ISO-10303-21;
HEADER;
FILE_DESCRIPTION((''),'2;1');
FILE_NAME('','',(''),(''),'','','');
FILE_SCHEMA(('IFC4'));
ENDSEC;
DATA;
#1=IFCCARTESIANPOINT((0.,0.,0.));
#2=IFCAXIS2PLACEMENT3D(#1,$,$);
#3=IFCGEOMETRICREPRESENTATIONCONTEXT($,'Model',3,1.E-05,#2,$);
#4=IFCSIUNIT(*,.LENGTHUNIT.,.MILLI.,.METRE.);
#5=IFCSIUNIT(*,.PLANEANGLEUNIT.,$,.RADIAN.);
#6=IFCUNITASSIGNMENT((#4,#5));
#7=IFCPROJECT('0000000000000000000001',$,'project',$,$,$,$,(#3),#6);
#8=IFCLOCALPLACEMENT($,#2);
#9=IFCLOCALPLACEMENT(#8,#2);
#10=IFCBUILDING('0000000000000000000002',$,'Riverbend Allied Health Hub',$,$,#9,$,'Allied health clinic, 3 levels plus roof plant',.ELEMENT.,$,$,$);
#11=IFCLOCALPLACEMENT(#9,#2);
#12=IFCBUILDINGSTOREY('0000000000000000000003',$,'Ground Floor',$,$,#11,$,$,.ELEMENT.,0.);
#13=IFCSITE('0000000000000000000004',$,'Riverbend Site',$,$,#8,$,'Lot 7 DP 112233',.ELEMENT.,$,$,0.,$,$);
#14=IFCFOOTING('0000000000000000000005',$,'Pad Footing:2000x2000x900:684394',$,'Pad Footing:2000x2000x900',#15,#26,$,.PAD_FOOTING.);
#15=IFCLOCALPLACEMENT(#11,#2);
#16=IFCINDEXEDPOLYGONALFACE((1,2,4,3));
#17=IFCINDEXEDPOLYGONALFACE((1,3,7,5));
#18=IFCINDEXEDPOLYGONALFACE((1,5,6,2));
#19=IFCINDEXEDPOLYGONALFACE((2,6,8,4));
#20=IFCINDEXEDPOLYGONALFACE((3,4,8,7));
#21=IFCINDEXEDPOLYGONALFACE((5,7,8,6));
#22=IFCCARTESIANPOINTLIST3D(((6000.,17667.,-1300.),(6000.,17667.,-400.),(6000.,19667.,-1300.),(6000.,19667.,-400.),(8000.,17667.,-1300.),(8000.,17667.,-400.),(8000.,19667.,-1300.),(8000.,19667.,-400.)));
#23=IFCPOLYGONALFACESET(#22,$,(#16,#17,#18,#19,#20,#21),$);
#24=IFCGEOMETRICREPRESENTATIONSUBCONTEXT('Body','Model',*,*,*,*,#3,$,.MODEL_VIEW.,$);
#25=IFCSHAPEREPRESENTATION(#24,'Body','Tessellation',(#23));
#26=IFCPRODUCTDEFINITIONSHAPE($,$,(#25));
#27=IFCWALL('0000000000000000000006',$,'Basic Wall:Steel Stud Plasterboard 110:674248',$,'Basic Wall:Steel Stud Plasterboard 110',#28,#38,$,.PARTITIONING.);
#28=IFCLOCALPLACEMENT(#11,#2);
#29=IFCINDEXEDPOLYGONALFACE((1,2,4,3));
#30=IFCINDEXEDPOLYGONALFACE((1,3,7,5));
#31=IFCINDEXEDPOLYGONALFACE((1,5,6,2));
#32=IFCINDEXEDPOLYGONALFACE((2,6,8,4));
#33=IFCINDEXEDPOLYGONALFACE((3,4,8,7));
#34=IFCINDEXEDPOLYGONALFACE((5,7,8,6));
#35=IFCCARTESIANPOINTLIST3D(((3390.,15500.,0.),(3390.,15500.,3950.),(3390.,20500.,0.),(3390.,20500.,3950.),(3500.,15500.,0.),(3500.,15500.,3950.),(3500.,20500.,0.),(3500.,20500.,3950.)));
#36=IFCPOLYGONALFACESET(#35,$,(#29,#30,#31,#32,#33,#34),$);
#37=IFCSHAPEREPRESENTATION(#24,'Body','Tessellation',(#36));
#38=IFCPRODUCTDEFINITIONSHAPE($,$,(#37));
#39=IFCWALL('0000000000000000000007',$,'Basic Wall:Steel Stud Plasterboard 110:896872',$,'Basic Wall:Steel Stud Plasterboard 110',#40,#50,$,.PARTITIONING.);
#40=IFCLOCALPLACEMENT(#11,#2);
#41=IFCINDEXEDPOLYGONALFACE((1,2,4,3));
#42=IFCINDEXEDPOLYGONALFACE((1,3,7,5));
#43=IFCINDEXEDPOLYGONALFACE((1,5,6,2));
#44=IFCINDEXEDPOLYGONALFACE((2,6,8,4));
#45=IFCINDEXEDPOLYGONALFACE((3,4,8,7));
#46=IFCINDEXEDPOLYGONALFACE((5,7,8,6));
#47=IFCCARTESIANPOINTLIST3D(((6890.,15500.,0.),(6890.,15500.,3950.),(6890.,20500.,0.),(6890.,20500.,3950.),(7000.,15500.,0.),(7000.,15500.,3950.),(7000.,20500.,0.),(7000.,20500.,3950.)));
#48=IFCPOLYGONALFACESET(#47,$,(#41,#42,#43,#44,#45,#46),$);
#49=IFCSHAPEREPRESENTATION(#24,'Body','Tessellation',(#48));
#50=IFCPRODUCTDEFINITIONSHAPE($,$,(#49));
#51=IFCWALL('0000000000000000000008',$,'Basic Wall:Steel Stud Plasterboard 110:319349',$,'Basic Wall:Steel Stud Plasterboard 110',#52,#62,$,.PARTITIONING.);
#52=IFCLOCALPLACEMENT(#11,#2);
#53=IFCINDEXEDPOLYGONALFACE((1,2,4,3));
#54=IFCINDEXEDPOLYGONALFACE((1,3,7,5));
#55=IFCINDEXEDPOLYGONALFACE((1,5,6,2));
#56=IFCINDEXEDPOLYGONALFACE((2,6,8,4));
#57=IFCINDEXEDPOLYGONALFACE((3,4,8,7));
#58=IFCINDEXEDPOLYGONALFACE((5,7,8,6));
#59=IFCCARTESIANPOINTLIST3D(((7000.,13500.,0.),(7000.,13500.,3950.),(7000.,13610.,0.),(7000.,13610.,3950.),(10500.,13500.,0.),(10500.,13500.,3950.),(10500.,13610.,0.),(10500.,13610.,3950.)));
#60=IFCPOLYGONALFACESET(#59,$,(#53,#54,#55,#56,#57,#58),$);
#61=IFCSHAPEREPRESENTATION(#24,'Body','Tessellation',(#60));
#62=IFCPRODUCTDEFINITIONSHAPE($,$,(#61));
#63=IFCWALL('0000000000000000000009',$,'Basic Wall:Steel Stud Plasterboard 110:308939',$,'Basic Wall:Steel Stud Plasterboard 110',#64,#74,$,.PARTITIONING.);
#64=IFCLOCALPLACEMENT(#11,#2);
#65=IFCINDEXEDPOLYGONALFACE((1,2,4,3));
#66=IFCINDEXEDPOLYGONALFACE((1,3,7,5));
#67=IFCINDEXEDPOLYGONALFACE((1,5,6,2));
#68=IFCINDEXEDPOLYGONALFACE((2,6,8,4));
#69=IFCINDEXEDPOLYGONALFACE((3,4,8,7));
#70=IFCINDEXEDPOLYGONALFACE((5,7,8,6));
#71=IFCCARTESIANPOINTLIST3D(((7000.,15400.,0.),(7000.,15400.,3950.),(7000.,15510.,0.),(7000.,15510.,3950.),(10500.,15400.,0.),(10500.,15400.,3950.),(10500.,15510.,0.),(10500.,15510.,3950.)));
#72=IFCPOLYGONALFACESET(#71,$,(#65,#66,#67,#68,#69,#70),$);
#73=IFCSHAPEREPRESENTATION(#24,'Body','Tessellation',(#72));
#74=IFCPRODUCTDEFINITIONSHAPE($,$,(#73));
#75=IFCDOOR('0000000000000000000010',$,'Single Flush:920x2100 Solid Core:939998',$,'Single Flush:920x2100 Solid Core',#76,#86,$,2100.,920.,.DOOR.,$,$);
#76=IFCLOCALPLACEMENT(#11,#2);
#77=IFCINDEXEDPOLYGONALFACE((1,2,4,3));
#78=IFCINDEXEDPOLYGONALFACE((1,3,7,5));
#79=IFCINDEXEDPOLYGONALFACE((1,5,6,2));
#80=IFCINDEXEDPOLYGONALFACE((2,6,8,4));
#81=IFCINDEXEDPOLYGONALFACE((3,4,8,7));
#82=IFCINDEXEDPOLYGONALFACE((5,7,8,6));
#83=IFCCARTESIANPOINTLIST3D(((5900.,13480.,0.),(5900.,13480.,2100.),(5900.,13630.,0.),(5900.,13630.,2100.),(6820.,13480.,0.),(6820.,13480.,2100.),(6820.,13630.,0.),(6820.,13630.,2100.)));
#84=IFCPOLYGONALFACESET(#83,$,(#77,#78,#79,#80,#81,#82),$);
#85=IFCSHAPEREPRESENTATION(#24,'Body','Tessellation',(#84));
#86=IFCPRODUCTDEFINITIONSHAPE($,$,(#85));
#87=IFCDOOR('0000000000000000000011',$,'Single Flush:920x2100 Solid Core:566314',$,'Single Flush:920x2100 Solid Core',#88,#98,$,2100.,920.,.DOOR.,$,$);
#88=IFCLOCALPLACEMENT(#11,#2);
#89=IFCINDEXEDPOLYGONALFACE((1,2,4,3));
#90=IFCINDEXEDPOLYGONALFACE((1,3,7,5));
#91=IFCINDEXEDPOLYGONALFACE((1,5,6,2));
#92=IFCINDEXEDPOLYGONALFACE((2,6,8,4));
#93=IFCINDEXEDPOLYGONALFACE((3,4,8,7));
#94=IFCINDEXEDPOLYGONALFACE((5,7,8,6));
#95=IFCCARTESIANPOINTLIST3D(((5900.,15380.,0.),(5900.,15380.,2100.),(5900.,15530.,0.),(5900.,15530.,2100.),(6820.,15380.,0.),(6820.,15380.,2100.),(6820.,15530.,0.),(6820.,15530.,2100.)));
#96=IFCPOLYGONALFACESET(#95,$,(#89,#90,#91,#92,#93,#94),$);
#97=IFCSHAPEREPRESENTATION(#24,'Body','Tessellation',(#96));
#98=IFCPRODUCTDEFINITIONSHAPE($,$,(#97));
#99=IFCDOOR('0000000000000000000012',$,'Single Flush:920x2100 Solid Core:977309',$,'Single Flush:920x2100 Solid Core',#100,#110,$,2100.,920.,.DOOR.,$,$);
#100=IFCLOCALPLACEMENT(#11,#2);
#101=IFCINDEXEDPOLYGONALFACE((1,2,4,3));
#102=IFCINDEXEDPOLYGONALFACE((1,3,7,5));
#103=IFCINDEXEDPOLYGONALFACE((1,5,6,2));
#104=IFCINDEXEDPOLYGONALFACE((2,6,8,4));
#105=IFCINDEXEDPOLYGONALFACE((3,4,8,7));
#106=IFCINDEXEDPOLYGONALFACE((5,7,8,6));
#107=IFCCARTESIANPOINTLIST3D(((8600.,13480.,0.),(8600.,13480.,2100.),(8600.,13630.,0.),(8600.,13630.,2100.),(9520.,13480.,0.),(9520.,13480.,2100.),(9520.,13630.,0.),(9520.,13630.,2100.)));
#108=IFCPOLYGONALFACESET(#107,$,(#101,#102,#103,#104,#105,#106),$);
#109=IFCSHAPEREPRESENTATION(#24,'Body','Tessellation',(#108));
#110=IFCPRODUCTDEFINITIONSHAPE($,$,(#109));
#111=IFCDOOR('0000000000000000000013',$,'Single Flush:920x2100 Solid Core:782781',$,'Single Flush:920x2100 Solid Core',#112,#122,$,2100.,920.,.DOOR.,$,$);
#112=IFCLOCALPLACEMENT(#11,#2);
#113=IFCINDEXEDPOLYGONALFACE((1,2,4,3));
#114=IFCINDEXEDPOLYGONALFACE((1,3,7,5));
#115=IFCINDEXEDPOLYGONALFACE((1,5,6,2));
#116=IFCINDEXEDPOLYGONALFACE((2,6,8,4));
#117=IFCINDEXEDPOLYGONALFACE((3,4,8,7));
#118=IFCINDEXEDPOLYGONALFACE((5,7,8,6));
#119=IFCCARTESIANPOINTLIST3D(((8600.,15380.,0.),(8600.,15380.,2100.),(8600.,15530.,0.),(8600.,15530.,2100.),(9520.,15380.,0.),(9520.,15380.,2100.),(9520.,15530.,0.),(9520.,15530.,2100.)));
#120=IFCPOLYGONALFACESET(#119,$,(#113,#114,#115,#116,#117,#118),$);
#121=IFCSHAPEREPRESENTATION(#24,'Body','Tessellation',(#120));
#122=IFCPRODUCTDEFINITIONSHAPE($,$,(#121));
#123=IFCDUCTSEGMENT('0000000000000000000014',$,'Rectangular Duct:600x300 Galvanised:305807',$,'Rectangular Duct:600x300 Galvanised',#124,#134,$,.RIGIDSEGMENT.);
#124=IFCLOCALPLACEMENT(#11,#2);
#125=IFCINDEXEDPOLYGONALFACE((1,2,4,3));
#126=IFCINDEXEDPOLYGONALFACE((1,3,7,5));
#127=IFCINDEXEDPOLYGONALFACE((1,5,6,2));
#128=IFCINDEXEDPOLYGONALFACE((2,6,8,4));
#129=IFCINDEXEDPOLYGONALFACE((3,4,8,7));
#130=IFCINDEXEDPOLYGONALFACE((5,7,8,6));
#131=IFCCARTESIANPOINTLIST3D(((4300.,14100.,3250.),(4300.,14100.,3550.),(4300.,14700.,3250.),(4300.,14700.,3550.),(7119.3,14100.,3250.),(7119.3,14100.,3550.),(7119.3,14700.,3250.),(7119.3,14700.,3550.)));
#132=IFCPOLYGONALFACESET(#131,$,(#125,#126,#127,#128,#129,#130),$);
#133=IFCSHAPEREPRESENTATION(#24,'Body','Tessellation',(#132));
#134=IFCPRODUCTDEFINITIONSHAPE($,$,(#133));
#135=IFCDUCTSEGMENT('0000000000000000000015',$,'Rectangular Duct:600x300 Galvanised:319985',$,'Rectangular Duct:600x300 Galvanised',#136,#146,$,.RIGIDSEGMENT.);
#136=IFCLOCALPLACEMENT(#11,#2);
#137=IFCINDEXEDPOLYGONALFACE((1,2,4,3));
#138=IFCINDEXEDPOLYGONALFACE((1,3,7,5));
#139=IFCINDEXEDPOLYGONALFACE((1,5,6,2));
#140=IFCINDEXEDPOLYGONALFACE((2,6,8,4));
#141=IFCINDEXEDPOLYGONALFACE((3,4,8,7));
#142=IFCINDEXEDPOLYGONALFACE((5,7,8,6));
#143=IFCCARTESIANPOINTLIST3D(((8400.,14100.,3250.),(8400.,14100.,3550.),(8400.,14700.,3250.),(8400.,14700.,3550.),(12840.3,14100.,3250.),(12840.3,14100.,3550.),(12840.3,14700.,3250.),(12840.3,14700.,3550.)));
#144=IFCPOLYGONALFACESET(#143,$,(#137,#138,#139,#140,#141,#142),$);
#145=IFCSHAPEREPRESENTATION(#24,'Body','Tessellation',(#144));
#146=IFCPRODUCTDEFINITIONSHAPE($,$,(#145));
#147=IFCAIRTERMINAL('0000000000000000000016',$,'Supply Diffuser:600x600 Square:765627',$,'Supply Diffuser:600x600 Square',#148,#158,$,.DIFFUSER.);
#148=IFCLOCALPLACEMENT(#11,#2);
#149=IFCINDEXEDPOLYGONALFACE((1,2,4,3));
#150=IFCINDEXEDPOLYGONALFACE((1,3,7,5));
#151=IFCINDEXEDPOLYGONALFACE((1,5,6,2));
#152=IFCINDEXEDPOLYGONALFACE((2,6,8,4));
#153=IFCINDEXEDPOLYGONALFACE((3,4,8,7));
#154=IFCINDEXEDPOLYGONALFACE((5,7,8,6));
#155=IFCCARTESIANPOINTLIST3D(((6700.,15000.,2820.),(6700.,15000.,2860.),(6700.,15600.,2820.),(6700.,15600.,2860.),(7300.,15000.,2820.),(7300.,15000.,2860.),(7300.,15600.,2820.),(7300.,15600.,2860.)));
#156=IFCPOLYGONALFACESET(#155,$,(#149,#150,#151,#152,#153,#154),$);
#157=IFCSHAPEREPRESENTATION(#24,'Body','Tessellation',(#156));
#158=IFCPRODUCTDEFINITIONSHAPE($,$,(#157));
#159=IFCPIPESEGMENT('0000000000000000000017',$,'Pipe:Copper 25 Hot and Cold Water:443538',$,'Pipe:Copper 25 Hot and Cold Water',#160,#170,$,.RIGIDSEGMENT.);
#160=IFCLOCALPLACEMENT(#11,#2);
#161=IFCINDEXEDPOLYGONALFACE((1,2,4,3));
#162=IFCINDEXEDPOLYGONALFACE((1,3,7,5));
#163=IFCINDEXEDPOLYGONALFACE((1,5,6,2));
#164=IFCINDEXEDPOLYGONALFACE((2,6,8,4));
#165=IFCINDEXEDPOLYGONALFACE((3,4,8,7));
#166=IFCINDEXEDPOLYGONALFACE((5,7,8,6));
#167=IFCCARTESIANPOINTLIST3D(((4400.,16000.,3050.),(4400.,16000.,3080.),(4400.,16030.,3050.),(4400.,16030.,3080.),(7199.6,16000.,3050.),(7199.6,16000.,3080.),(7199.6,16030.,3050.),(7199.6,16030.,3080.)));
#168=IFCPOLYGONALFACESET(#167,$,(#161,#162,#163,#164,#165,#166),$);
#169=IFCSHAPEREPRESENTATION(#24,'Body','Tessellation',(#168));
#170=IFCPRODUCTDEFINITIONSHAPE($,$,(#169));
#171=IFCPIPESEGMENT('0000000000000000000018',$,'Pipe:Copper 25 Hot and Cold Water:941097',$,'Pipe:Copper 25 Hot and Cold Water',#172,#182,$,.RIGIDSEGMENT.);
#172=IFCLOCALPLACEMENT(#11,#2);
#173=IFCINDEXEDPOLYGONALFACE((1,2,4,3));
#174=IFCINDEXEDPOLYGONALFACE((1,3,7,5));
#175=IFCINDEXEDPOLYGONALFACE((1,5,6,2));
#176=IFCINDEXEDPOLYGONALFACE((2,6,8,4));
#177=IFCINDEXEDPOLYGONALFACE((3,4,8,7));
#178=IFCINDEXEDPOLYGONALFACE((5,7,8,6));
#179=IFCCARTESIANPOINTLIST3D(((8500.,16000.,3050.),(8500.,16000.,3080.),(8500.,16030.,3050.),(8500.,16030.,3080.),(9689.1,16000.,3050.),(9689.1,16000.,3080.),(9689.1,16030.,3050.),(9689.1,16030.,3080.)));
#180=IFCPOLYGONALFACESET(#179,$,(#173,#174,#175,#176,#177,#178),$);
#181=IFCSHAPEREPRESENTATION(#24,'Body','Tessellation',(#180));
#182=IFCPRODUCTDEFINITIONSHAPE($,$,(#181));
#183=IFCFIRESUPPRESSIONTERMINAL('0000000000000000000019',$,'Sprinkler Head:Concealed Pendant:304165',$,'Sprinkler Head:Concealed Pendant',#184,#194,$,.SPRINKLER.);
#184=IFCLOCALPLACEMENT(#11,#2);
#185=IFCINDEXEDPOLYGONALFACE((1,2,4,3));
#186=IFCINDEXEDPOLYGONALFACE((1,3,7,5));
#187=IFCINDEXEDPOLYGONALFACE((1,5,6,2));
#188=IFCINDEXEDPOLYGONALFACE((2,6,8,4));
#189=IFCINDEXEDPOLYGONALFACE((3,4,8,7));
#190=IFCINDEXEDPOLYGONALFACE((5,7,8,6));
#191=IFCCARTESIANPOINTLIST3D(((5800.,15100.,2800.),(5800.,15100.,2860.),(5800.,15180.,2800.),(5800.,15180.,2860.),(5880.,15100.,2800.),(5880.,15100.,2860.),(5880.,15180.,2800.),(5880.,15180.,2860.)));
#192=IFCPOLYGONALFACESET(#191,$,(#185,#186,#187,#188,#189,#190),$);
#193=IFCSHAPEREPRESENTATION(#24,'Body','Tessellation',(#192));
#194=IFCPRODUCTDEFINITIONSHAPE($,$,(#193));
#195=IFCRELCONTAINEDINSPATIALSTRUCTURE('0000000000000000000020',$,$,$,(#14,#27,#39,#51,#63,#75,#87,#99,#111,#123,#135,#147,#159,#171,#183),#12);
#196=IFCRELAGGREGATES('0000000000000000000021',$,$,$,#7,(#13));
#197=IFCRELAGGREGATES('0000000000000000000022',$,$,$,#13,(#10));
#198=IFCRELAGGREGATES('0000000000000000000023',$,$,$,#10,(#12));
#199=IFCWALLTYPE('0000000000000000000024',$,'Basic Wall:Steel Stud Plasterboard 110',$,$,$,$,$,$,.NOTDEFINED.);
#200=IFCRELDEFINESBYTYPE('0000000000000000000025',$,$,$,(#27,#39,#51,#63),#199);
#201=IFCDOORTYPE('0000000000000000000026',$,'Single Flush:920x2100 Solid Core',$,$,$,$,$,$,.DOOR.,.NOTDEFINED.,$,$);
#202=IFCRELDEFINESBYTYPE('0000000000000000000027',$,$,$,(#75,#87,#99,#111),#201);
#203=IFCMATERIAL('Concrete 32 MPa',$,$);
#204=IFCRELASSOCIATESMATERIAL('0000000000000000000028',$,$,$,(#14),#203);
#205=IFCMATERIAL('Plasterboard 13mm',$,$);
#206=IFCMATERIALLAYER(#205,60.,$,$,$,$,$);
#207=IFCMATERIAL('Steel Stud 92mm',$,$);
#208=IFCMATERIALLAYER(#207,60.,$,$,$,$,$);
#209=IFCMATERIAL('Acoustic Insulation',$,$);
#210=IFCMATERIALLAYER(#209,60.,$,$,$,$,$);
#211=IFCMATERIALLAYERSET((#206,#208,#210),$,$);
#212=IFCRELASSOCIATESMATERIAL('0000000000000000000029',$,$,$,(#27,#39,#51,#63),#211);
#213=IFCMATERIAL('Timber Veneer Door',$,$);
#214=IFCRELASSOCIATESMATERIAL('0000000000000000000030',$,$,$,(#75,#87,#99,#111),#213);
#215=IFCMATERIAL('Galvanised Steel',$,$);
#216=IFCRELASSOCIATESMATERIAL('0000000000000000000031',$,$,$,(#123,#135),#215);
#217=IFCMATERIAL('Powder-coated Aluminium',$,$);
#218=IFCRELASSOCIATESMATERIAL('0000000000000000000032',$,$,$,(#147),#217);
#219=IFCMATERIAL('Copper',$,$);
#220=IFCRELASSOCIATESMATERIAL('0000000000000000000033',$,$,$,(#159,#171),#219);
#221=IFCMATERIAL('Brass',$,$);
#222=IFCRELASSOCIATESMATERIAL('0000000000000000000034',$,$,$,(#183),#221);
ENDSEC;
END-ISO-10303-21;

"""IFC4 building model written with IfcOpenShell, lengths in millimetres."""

from ifc_helpers import new_model, si_unit, frame, frame_2d, origin, place, context, subcontext, project, spatial, rectangle, extrude, material, layer, layer_set, layer_usage, type_object, element, save


model = new_model("IFC4")

# Units and contexts
model_context = context("Model", 3, precision=1e-05, world=origin())
body_context = subcontext(model_context, "Body", "Model", "MODEL_VIEW")
ifc_project = project(units=[si_unit("LENGTHUNIT", "METRE", prefix="MILLI"), si_unit("PLANEANGLEUNIT", "RADIAN")], contexts=[model_context])

# Site, building, storey
site_placement = place(None, origin())
site = spatial("IfcSite", under=ifc_project, at=site_placement, Name="Riverbend Site", LongName="Lot 7 DP 112233", CompositionType="ELEMENT", RefElevation=0.0)
building_placement = place(site_placement, origin())
building = spatial("IfcBuilding", under=site, at=building_placement, Name="Riverbend Allied Health Hub", LongName="Allied health clinic, 3 levels plus roof plant", CompositionType="ELEMENT")
storey_placement = place(building_placement, origin())
storey = spatial("IfcBuildingStorey", under=building, at=storey_placement, Name="Ground Floor", CompositionType="ELEMENT", Elevation=0.0)

# Footing
ifc_material_1 = material(Name="Concrete 32 MPa")
footing_placement = place(storey_placement, frame((6000.0, 17667.0, -1300.0)))
element("IfcFooting", 1, at=footing_placement, inside=storey, material=ifc_material_1, Name="Pad Footing:2000x2000x900:684394", ObjectType="Pad Footing:2000x2000x900", PredefinedType="PAD_FOOTING", context=body_context, shape_type="SweptSolid", body=[
    extrude(rectangle(XDim=2000.0, YDim=2000.0, at=frame_2d((1000.0, 1000.0))), origin(), (0.0, 0.0, 1.0), 900.0),
])

# Walls
ifc_material_2 = material(Name="Plasterboard 13mm")
ifc_layer_1 = layer(ifc_material_2, 60.0)
ifc_material_3 = material(Name="Steel Stud 92mm")
ifc_layer_2 = layer(ifc_material_3, 60.0)
ifc_material_4 = material(Name="Acoustic Insulation")
ifc_layer_3 = layer(ifc_material_4, 60.0)
ifc_layer_set = layer_set([ifc_layer_1, ifc_layer_2, ifc_layer_3])
ifc_layer_usage = layer_usage(ifc_layer_set, "AXIS2", "POSITIVE", 0.0)
wall_type = type_object("IfcWallType", Name="Basic Wall:Steel Stud Plasterboard 110", PredefinedType="NOTDEFINED")
for number, where, z_axis, x_axis, name in (
    (2, (3500.0, 15500.0, 0.0), (0.0, 0.0, 1.0), (0.0, 1.0, 0.0), "Basic Wall:Steel Stud Plasterboard 110:674248"),
    (3, (7000.0, 15500.0, 0.0), (0.0, 0.0, 1.0), (0.0, 1.0, 0.0), "Basic Wall:Steel Stud Plasterboard 110:896872"),
):
    element("IfcWall", number, at=place(storey_placement, frame(where, z_axis=z_axis, x_axis=x_axis)), inside=storey, type_object=wall_type, material=ifc_layer_usage, Name=name, ObjectType="Basic Wall:Steel Stud Plasterboard 110", PredefinedType="PARTITIONING", context=body_context, shape_type="SweptSolid", body=[
        extrude(rectangle(XDim=5000.0, YDim=110.0, at=frame_2d((2500.0, 55.0))), origin(), (0.0, 0.0, 1.0), 3950.0),
    ])
for number, where, name in (
    (4, (7000.0, 13500.0, 0.0), "Basic Wall:Steel Stud Plasterboard 110:319349"),
    (5, (7000.0, 15400.0, 0.0), "Basic Wall:Steel Stud Plasterboard 110:308939"),
):
    element("IfcWall", number, at=place(storey_placement, frame(where)), inside=storey, type_object=wall_type, material=ifc_layer_usage, Name=name, ObjectType="Basic Wall:Steel Stud Plasterboard 110", PredefinedType="PARTITIONING", context=body_context, shape_type="SweptSolid", body=[
        extrude(rectangle(XDim=3500.0, YDim=110.0, at=frame_2d((1750.0, 55.0))), origin(), (0.0, 0.0, 1.0), 3950.0),
    ])

# Doors
ifc_material_5 = material(Name="Timber Veneer Door")
door_type = type_object("IfcDoorType", Name="Single Flush:920x2100 Solid Core", OperationType="NOTDEFINED", PredefinedType="DOOR")
for number, where, name in (
    (6, (5900.0, 13480.0, 0.0), "Single Flush:920x2100 Solid Core:939998"),
    (7, (5900.0, 15380.0, 0.0), "Single Flush:920x2100 Solid Core:566314"),
    (8, (8600.0, 13480.0, 0.0), "Single Flush:920x2100 Solid Core:977309"),
    (9, (8600.0, 15380.0, 0.0), "Single Flush:920x2100 Solid Core:782781"),
):
    element("IfcDoor", number, at=place(storey_placement, frame(where)), inside=storey, type_object=door_type, material=ifc_material_5, Name=name, ObjectType="Single Flush:920x2100 Solid Core", OverallHeight=2100.0, OverallWidth=920.0, PredefinedType="DOOR", context=body_context, shape_type="SweptSolid", body=[
        extrude(rectangle(XDim=920.0, YDim=150.0, at=frame_2d((460.0, 75.0))), origin(), (0.0, 0.0, 1.0), 2100.0),
    ])

# Duct segments
ifc_material_6 = material(Name="Galvanised Steel")
duct_segment_1_placement = place(storey_placement, frame((4300.0, 14100.0, 3250.0)))
element("IfcDuctSegment", 10, at=duct_segment_1_placement, inside=storey, material=ifc_material_6, Name="Rectangular Duct:600x300 Galvanised:305807", ObjectType="Rectangular Duct:600x300 Galvanised", PredefinedType="RIGIDSEGMENT", context=body_context, shape_type="SweptSolid", body=[
    extrude(rectangle(XDim=2819.3, YDim=600.0, at=frame_2d((1409.7, 300.0))), origin(), (0.0, 0.0, 1.0), 300.0),
])
duct_segment_2_placement = place(storey_placement, frame((8400.0, 14100.0, 3250.0)))
element("IfcDuctSegment", 11, at=duct_segment_2_placement, inside=storey, material=ifc_material_6, Name="Rectangular Duct:600x300 Galvanised:319985", ObjectType="Rectangular Duct:600x300 Galvanised", PredefinedType="RIGIDSEGMENT", context=body_context, shape_type="SweptSolid", body=[
    extrude(rectangle(XDim=4440.3, YDim=600.0, at=frame_2d((2220.2, 300.0))), origin(), (0.0, 0.0, 1.0), 300.0),
])

# Air terminal
ifc_material_7 = material(Name="Powder-coated Aluminium")
air_terminal_placement = place(storey_placement, frame((6700.0, 15000.0, 2820.0)))
element("IfcAirTerminal", 12, at=air_terminal_placement, inside=storey, material=ifc_material_7, Name="Supply Diffuser:600x600 Square:765627", ObjectType="Supply Diffuser:600x600 Square", PredefinedType="DIFFUSER", context=body_context, shape_type="SweptSolid", body=[
    extrude(rectangle(XDim=600.0, YDim=600.0, at=frame_2d((300.0, 300.0))), origin(), (0.0, 0.0, 1.0), 40.0),
])

# Pipe segments
ifc_material_8 = material(Name="Copper")
pipe_segment_1_placement = place(storey_placement, frame((4400.0, 16000.0, 3050.0)))
element("IfcPipeSegment", 13, at=pipe_segment_1_placement, inside=storey, material=ifc_material_8, Name="Pipe:Copper 25 Hot and Cold Water:443538", ObjectType="Pipe:Copper 25 Hot and Cold Water", PredefinedType="RIGIDSEGMENT", context=body_context, shape_type="SweptSolid", body=[
    extrude(rectangle(XDim=2799.6, YDim=30.0, at=frame_2d((1399.8, 15.0))), origin(), (0.0, 0.0, 1.0), 30.0),
])
pipe_segment_2_placement = place(storey_placement, frame((8500.0, 16000.0, 3050.0)))
element("IfcPipeSegment", 14, at=pipe_segment_2_placement, inside=storey, material=ifc_material_8, Name="Pipe:Copper 25 Hot and Cold Water:941097", ObjectType="Pipe:Copper 25 Hot and Cold Water", PredefinedType="RIGIDSEGMENT", context=body_context, shape_type="SweptSolid", body=[
    extrude(rectangle(XDim=1189.1, YDim=30.0, at=frame_2d((594.5, 15.0))), origin(), (0.0, 0.0, 1.0), 30.0),
])

# Fire suppression terminal
ifc_material_9 = material(Name="Brass")
fire_suppression_terminal_placement = place(storey_placement, frame((5800.0, 15100.0, 2800.0)))
element("IfcFireSuppressionTerminal", 15, at=fire_suppression_terminal_placement, inside=storey, material=ifc_material_9, Name="Sprinkler Head:Concealed Pendant:304165", ObjectType="Sprinkler Head:Concealed Pendant", PredefinedType="SPRINKLER", context=body_context, shape_type="SweptSolid", body=[
    extrude(rectangle(XDim=80.0, YDim=80.0, at=frame_2d((40.0, 40.0))), origin(), (0.0, 0.0, 1.0), 60.0),
])

save(model, "model.ifc")
